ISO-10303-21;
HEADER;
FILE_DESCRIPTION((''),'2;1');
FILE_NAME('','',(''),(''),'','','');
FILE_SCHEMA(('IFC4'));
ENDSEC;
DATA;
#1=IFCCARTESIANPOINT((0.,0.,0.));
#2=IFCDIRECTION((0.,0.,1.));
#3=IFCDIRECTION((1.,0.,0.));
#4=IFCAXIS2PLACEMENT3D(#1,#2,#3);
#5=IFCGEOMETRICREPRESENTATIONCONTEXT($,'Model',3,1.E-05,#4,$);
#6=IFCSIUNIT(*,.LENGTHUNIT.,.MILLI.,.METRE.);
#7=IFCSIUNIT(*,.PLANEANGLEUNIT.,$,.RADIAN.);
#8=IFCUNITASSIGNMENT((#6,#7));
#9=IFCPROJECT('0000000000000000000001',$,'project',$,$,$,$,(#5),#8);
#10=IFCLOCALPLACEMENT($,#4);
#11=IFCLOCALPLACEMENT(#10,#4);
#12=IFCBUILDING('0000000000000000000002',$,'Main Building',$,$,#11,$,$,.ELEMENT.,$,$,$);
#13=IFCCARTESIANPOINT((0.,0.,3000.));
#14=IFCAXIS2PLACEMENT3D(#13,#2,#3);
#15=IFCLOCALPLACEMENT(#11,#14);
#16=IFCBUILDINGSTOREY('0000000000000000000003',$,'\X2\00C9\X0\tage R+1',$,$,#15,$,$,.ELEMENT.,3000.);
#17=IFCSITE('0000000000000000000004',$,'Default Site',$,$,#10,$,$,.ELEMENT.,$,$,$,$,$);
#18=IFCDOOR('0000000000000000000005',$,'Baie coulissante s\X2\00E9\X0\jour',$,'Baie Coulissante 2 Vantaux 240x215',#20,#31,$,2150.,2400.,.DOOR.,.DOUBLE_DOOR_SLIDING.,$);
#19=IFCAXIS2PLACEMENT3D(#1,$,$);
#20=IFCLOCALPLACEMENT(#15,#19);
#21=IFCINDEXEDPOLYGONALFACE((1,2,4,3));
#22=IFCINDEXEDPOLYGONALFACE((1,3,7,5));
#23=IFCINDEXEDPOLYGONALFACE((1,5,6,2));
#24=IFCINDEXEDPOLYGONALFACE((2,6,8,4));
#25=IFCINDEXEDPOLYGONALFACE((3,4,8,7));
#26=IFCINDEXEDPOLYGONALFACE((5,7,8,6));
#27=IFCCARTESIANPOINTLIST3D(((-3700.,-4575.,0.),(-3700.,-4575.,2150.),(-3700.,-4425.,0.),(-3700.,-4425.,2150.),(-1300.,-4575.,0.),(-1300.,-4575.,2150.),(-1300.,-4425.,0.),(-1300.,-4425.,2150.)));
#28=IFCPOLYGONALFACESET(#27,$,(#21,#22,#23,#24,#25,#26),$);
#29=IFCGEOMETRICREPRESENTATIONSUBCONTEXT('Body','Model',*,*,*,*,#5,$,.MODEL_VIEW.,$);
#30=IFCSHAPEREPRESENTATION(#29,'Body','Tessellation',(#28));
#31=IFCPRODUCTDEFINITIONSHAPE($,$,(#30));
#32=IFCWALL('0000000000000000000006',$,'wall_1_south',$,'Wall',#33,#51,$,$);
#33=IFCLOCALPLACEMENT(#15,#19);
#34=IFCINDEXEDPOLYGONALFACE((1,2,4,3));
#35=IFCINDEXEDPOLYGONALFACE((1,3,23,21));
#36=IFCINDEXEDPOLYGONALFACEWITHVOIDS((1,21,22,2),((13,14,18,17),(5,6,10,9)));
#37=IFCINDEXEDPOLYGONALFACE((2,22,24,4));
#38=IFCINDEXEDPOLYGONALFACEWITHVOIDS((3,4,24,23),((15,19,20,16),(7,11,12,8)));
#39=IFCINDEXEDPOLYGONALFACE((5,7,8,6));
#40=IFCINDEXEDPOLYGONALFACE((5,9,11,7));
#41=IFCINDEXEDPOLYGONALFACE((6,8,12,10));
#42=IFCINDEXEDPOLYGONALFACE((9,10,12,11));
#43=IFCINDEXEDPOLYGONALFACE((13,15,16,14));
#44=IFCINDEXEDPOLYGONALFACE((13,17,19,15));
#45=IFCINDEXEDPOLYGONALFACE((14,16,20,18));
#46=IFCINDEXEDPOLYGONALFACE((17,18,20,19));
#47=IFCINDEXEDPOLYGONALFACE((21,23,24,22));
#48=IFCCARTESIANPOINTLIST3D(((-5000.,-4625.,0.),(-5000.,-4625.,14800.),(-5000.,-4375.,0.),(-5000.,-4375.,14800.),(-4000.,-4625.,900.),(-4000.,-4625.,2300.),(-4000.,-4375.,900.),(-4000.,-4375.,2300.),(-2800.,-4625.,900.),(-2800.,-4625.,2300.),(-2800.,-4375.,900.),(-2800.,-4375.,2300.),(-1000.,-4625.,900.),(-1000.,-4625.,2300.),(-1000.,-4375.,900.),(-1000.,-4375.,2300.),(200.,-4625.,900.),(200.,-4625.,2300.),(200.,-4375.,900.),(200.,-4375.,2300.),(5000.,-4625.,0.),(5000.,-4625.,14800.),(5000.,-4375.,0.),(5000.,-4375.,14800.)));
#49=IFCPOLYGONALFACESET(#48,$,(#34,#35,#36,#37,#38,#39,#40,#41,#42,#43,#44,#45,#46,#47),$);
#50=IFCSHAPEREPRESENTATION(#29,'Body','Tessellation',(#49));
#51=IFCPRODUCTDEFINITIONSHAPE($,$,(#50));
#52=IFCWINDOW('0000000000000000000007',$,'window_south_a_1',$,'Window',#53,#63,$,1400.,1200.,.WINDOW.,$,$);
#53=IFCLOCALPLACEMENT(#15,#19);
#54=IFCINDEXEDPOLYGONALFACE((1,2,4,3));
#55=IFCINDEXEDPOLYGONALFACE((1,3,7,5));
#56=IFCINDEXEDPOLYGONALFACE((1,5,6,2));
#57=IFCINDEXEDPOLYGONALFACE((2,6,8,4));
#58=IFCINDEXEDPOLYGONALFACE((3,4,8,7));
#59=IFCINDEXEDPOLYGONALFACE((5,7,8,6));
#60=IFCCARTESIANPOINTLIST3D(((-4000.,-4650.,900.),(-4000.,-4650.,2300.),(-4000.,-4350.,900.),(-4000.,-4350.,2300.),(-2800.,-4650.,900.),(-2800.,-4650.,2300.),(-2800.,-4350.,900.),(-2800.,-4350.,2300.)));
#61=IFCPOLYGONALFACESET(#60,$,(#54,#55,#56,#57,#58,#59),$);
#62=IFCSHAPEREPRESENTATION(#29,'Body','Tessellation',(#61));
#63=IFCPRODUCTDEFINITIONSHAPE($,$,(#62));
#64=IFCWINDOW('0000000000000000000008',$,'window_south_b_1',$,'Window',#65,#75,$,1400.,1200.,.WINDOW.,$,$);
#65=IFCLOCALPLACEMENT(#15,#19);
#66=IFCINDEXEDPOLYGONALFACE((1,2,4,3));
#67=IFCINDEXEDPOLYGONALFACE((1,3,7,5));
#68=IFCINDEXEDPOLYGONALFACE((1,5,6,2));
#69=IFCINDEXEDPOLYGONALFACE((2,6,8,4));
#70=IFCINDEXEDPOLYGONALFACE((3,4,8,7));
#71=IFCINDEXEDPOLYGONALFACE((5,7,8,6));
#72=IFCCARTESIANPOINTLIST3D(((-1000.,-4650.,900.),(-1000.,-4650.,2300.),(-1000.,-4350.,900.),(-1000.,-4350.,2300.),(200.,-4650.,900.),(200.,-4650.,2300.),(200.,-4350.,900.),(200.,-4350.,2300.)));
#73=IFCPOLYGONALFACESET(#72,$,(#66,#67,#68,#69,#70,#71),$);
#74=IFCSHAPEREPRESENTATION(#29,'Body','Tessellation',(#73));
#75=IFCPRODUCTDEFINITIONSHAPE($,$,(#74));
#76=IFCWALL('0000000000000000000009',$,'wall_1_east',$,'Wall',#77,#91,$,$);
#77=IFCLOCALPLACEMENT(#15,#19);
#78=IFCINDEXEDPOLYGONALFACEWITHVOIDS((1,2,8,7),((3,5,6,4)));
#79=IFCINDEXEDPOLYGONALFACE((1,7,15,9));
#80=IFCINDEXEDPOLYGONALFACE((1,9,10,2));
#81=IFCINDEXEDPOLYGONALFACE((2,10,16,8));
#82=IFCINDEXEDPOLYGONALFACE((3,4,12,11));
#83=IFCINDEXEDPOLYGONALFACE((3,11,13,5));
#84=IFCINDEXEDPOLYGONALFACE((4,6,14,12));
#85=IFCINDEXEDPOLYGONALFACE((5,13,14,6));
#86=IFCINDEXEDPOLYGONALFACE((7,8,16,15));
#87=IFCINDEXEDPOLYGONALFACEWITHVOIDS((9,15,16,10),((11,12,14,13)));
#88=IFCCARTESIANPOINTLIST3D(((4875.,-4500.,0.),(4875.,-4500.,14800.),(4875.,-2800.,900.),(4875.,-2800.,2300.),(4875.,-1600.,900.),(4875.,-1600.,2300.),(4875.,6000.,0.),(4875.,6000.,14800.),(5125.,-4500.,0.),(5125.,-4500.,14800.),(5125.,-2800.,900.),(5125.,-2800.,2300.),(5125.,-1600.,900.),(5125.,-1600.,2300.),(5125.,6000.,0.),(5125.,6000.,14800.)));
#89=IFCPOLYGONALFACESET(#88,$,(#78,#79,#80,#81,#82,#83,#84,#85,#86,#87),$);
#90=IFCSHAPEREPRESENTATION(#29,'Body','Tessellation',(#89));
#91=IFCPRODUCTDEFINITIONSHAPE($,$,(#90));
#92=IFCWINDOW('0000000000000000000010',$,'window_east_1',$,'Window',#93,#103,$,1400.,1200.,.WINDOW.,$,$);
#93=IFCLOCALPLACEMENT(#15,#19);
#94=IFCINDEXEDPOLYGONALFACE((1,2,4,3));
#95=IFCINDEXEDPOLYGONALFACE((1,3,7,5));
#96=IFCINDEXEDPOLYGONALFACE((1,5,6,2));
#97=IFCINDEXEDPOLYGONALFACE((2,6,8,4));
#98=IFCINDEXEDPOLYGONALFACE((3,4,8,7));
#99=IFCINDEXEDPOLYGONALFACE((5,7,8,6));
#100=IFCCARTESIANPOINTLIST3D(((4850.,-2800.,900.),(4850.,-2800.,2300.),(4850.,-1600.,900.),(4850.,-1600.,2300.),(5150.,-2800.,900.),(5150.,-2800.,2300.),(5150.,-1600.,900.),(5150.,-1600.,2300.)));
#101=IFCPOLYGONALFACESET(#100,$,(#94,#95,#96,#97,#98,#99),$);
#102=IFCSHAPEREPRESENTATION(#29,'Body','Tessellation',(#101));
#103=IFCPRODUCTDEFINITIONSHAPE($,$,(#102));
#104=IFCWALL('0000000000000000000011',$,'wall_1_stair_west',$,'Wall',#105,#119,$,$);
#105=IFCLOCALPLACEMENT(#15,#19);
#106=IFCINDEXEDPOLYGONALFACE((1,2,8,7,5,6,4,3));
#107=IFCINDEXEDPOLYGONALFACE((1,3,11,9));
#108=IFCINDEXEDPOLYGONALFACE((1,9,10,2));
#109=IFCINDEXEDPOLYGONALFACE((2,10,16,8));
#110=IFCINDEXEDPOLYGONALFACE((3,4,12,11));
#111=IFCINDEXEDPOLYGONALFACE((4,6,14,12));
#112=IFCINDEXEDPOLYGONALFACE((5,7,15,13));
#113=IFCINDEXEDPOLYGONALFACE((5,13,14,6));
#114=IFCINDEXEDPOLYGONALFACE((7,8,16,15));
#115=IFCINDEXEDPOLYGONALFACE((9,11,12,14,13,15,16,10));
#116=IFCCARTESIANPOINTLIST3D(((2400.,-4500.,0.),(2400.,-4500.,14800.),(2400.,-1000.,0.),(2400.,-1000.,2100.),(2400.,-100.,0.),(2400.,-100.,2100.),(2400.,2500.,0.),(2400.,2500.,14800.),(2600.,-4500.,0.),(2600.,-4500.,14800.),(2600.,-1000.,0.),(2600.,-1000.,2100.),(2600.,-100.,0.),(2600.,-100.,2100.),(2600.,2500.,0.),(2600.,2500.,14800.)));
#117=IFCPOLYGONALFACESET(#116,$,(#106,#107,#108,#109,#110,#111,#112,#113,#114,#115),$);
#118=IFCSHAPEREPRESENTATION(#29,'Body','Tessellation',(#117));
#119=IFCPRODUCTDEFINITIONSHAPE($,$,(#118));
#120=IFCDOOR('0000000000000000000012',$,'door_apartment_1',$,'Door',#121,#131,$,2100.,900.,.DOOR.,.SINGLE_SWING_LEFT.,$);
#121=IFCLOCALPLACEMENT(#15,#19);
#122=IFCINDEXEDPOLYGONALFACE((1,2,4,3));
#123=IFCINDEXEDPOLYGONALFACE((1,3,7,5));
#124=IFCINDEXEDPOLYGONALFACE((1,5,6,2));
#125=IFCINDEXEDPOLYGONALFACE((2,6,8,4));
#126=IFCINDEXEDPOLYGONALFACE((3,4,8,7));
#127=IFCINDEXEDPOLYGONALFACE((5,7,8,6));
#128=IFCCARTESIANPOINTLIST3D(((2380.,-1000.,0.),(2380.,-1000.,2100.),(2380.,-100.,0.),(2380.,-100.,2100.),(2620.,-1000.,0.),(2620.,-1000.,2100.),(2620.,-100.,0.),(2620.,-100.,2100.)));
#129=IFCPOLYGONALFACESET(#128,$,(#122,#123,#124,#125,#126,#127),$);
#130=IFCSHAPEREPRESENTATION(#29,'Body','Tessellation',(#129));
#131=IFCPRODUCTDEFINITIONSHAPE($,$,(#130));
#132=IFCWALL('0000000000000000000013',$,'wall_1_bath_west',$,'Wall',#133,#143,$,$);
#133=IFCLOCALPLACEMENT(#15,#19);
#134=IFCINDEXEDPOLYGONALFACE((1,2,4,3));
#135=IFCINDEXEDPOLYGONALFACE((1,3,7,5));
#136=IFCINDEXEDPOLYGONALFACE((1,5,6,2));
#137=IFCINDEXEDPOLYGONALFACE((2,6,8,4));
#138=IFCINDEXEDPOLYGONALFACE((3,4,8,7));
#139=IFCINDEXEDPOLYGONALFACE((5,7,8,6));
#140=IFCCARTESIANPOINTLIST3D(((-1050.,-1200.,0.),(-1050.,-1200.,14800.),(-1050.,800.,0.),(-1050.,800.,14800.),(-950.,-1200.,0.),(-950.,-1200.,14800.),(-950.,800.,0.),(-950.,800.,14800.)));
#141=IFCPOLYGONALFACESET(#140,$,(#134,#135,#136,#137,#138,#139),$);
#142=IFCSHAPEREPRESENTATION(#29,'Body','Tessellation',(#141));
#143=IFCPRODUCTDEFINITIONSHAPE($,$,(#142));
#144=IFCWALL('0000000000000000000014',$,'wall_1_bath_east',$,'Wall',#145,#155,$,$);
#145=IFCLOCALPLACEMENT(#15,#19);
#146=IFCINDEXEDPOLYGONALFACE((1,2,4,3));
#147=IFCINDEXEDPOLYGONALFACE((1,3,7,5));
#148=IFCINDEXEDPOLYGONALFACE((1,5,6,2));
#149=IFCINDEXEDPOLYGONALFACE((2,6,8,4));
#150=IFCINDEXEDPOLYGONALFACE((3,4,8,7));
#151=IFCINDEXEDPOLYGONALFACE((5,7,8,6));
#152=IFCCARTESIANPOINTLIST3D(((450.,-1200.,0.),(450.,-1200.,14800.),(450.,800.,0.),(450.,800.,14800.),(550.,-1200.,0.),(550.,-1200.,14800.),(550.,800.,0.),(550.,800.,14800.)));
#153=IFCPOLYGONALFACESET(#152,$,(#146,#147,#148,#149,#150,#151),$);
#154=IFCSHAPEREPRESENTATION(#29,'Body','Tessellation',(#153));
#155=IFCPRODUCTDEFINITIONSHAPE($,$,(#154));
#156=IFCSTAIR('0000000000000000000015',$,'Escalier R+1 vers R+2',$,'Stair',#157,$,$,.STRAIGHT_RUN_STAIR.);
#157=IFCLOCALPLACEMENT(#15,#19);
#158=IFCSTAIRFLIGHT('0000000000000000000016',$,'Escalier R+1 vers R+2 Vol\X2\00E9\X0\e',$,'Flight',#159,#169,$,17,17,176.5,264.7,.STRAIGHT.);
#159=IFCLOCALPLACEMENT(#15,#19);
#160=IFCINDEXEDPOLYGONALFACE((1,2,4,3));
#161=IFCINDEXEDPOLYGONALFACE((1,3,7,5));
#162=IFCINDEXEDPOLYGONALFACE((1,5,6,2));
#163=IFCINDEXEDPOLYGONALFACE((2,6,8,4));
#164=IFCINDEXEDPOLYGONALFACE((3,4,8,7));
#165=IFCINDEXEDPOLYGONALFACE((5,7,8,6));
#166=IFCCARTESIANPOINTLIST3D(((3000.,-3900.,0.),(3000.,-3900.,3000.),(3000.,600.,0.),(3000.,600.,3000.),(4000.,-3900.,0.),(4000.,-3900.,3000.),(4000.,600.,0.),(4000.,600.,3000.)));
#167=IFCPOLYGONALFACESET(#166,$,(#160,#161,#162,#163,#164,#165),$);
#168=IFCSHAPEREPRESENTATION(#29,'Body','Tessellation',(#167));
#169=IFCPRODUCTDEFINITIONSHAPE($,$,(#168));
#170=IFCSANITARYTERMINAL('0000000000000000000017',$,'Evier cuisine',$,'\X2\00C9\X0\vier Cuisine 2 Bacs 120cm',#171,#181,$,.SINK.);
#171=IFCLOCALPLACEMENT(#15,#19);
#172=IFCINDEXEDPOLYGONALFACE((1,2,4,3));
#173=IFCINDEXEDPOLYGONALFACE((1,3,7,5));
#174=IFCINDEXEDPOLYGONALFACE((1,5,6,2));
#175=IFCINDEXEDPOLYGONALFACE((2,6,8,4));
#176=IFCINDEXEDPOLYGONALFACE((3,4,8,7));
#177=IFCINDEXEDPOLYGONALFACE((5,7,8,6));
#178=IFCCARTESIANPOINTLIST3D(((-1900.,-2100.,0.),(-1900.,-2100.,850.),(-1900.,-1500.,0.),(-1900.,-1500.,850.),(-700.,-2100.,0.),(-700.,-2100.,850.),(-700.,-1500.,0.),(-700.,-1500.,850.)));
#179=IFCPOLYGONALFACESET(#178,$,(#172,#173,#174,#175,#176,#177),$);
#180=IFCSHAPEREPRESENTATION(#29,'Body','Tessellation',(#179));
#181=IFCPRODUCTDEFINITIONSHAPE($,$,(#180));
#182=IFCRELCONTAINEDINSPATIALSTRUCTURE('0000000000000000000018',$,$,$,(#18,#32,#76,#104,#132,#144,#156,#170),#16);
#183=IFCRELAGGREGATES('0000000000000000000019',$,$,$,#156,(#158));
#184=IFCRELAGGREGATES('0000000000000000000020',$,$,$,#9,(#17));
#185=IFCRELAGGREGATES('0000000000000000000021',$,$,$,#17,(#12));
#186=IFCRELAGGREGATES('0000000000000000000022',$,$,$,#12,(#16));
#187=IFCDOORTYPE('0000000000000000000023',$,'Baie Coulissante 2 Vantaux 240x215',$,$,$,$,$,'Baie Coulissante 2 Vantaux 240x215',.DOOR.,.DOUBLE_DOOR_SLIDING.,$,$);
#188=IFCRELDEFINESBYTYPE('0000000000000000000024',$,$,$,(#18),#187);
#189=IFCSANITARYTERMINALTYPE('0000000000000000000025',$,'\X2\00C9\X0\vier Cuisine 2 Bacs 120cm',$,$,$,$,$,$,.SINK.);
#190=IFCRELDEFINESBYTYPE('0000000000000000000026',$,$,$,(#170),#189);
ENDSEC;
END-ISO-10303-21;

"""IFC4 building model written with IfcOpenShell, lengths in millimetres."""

from ifc_helpers import new_model, si_unit, frame, origin_with_axes, place, context, subcontext, project, spatial, polyline, outline, extrude, type_object, element, fill, aggregate, save


model = new_model("IFC4")

# Units and contexts
model_context = context("Model", 3, precision=1e-05, world=origin_with_axes())
body_context = subcontext(model_context, "Body", "Model", "MODEL_VIEW")
ifc_project = project(units=[si_unit("LENGTHUNIT", "METRE", prefix="MILLI"), si_unit("PLANEANGLEUNIT", "RADIAN")], contexts=[model_context])

# Site, building, storey
site_placement = place(None, origin_with_axes())
site = spatial("IfcSite", under=ifc_project, at=site_placement, Name="Default Site", CompositionType="ELEMENT")
building_placement = place(site_placement, origin_with_axes())
building = spatial("IfcBuilding", under=site, at=building_placement, Name="Main Building", CompositionType="ELEMENT")
storey_placement = place(building_placement, frame((0.0, 0.0, 3000.0), z_axis=(0.0, 0.0, 1.0), x_axis=(1.0, 0.0, 0.0)))
storey = spatial("IfcBuildingStorey", under=building, at=storey_placement, Name="Étage R+1", CompositionType="ELEMENT", Elevation=3000.0)

# Door
door_type = type_object("IfcDoorType", Name="Baie Coulissante 2 Vantaux 240x215", ElementType="Baie Coulissante 2 Vantaux 240x215", OperationType="DOUBLE_DOOR_SLIDING", PredefinedType="DOOR")
door_1_placement = place(storey_placement, frame((-2500.0, -4500.0, 0.0), z_axis=(0.0, 0.0, 1.0), x_axis=(1.0, 0.0, 0.0)))
element("IfcDoor", 1, at=door_1_placement, inside=storey, type_object=door_type, Name="Baie coulissante séjour", ObjectType="Baie Coulissante 2 Vantaux 240x215", OperationType="DOUBLE_DOOR_SLIDING", OverallHeight=2150.0, OverallWidth=2400.0, PredefinedType="DOOR", context=body_context, shape_type="SweptSolid", body=[
    extrude(outline(polyline([(-1200.0, -75.0), (1200.0, -75.0), (1200.0, 75.0), (-1200.0, 75.0), (-1200.0, -75.0)])), origin_with_axes(), (0.0, 0.0, 1.0), 2150.0),
])

# Wall, openings, windows
wall_1_placement = place(storey_placement, frame((-5000.0, -4500.0, 0.0), z_axis=(0.0, 0.0, 1.0), x_axis=(1.0, 0.0, 0.0)))
wall_1 = element("IfcWall", 2, at=wall_1_placement, inside=storey, Name="wall_1_south", ObjectType="Wall", context=body_context, shape_type="SweptSolid", body=[
    extrude(outline(polyline([(0.0, -125.0), (10000.0, -125.0), (10000.0, 125.0), (0.0, 125.0), (0.0, -125.0)])), origin_with_axes(), (0.0, 0.0, 1.0), 14800.0),
])
placement_1 = place(wall_1_placement, frame((1000.0, 0.0, 900.0), z_axis=(0.0, 0.0, 1.0), x_axis=(1.0, 0.0, 0.0)))
opening_1 = element("IfcOpeningElement", 3, at=placement_1, cuts=wall_1, PredefinedType="OPENING", context=body_context, shape_type="SweptSolid", body=[
    extrude(outline(polyline([(0.0, -150.0), (1200.0, -150.0), (1200.0, 150.0), (0.0, 150.0), (0.0, -150.0)])), origin_with_axes(), (0.0, 0.0, 1.0), 1400.0),
])
placement_2 = place(wall_1_placement, frame((4000.0, 0.0, 900.0), z_axis=(0.0, 0.0, 1.0), x_axis=(1.0, 0.0, 0.0)))
opening_2 = element("IfcOpeningElement", 4, at=placement_2, cuts=wall_1, PredefinedType="OPENING", context=body_context, shape_type="SweptSolid", body=[
    extrude(outline(polyline([(0.0, -150.0), (1200.0, -150.0), (1200.0, 150.0), (0.0, 150.0), (0.0, -150.0)])), origin_with_axes(), (0.0, 0.0, 1.0), 1400.0),
])
window_1 = element("IfcWindow", 5, at=placement_1, Name="window_south_a_1", ObjectType="Window", OverallHeight=1400.0, OverallWidth=1200.0, PredefinedType="WINDOW", context=body_context, shape_type="SweptSolid", body=[
    extrude(outline(polyline([(0.0, -150.0), (1200.0, -150.0), (1200.0, 150.0), (0.0, 150.0), (0.0, -150.0)])), origin_with_axes(), (0.0, 0.0, 1.0), 1400.0),
])
fill(opening_1, window_1)
window_2 = element("IfcWindow", 6, at=placement_2, Name="window_south_b_1", ObjectType="Window", OverallHeight=1400.0, OverallWidth=1200.0, PredefinedType="WINDOW", context=body_context, shape_type="SweptSolid", body=[
    extrude(outline(polyline([(0.0, -150.0), (1200.0, -150.0), (1200.0, 150.0), (0.0, 150.0), (0.0, -150.0)])), origin_with_axes(), (0.0, 0.0, 1.0), 1400.0),
])
fill(opening_2, window_2)

# Wall, opening, window
wall_2_placement = place(storey_placement, frame((5000.0, -4500.0, 0.0), z_axis=(0.0, 0.0, 1.0), x_axis=(0.0, 1.0, 0.0)))
wall_2 = element("IfcWall", 7, at=wall_2_placement, inside=storey, Name="wall_1_east", ObjectType="Wall", context=body_context, shape_type="SweptSolid", body=[
    extrude(outline(polyline([(0.0, -125.0), (10500.0, -125.0), (10500.0, 125.0), (0.0, 125.0), (0.0, -125.0)])), origin_with_axes(), (0.0, 0.0, 1.0), 14800.0),
])
placement_3 = place(wall_2_placement, frame((1700.0, 0.0, 900.0), z_axis=(0.0, 0.0, 1.0), x_axis=(1.0, 0.0, 0.0)))
opening_3 = element("IfcOpeningElement", 8, at=placement_3, cuts=wall_2, PredefinedType="OPENING", context=body_context, shape_type="SweptSolid", body=[
    extrude(outline(polyline([(0.0, -150.0), (1200.0, -150.0), (1200.0, 150.0), (0.0, 150.0), (0.0, -150.0)])), origin_with_axes(), (0.0, 0.0, 1.0), 1400.0),
])
window_3 = element("IfcWindow", 9, at=placement_3, Name="window_east_1", ObjectType="Window", OverallHeight=1400.0, OverallWidth=1200.0, PredefinedType="WINDOW", context=body_context, shape_type="SweptSolid", body=[
    extrude(outline(polyline([(0.0, -150.0), (1200.0, -150.0), (1200.0, 150.0), (0.0, 150.0), (0.0, -150.0)])), origin_with_axes(), (0.0, 0.0, 1.0), 1400.0),
])
fill(opening_3, window_3)

# Wall, opening, door
wall_3_placement = place(storey_placement, frame((2500.0, -4500.0, 0.0), z_axis=(0.0, 0.0, 1.0), x_axis=(0.0, 1.0, 0.0)))
wall_3 = element("IfcWall", 10, at=wall_3_placement, inside=storey, Name="wall_1_stair_west", ObjectType="Wall", context=body_context, shape_type="SweptSolid", body=[
    extrude(outline(polyline([(0.0, -100.0), (7000.0, -100.0), (7000.0, 100.0), (0.0, 100.0), (0.0, -100.0)])), origin_with_axes(), (0.0, 0.0, 1.0), 14800.0),
])
placement_4 = place(wall_3_placement, frame((3500.0, 0.0, 0.0), z_axis=(0.0, 0.0, 1.0), x_axis=(1.0, 0.0, 0.0)))
opening_4 = element("IfcOpeningElement", 11, at=placement_4, cuts=wall_3, PredefinedType="OPENING", context=body_context, shape_type="SweptSolid", body=[
    extrude(outline(polyline([(0.0, -120.0), (900.0, -120.0), (900.0, 120.0), (0.0, 120.0), (0.0, -120.0)])), origin_with_axes(), (0.0, 0.0, 1.0), 2100.0),
])
door_2 = element("IfcDoor", 12, at=placement_4, Name="door_apartment_1", ObjectType="Door", OperationType="SINGLE_SWING_LEFT", OverallHeight=2100.0, OverallWidth=900.0, PredefinedType="DOOR", context=body_context, shape_type="SweptSolid", body=[
    extrude(outline(polyline([(0.0, -120.0), (900.0, -120.0), (900.0, 120.0), (0.0, 120.0), (0.0, -120.0)])), origin_with_axes(), (0.0, 0.0, 1.0), 2100.0),
])
fill(opening_4, door_2)

# Walls
for number, where, z_axis, x_axis, name in (
    (13, (-1000.0, -1200.0, 0.0), (0.0, 0.0, 1.0), (0.0, 1.0, 0.0), "wall_1_bath_west"),
    (14, (500.0, -1200.0, 0.0), (0.0, 0.0, 1.0), (0.0, 1.0, 0.0), "wall_1_bath_east"),
):
    element("IfcWall", number, at=place(storey_placement, frame(where, z_axis=z_axis, x_axis=x_axis)), inside=storey, Name=name, ObjectType="Wall", context=body_context, shape_type="SweptSolid", body=[
        extrude(outline(polyline([(0.0, -50.0), (2000.0, -50.0), (2000.0, 50.0), (0.0, 50.0), (0.0, -50.0)])), origin_with_axes(), (0.0, 0.0, 1.0), 14800.0),
    ])

# Stair, stair flight
stair_placement = place(storey_placement, frame((3500.0, -3900.0, 0.0), z_axis=(0.0, 0.0, 1.0), x_axis=(0.0, 1.0, 0.0)))
stair = element("IfcStair", 15, at=stair_placement, inside=storey, Name="Escalier R+1 vers R+2", ObjectType="Stair", PredefinedType="STRAIGHT_RUN_STAIR")
stair_flight_placement = place(stair_placement, origin_with_axes())
stair_flight = element("IfcStairFlight", 16, at=stair_flight_placement, Name="Escalier R+1 vers R+2 Volée", ObjectType="Flight", NumberOfRisers=17, NumberOfTreads=17, PredefinedType="STRAIGHT", RiserHeight=176.5, TreadLength=264.7, context=body_context, shape_type="SweptSolid", body=[
    extrude(outline(polyline([(0.0, -500.0), (4500.0, -500.0), (4500.0, 500.0), (0.0, 500.0), (0.0, -500.0)])), origin_with_axes(), (0.0, 0.0, 1.0), 3000.0),
])
aggregate(stair, [stair_flight])

# Sanitary terminal
sanitary_terminal_type = type_object("IfcSanitaryTerminalType", Name="Évier Cuisine 2 Bacs 120cm", PredefinedType="SINK")
sanitary_terminal_placement = place(storey_placement, frame((-1300.0, -1800.0, 0.0), z_axis=(0.0, 0.0, 1.0), x_axis=(1.0, 0.0, 0.0)))
element("IfcSanitaryTerminal", 17, at=sanitary_terminal_placement, inside=storey, type_object=sanitary_terminal_type, Name="Evier cuisine", ObjectType="Évier Cuisine 2 Bacs 120cm", PredefinedType="SINK", context=body_context, shape_type="SweptSolid", body=[
    extrude(outline(polyline([(-600.0, -300.0), (600.0, -300.0), (600.0, 300.0), (-600.0, 300.0), (-600.0, -300.0)])), origin_with_axes(), (0.0, 0.0, 1.0), 850.0),
])

save(model, "model.ifc")
